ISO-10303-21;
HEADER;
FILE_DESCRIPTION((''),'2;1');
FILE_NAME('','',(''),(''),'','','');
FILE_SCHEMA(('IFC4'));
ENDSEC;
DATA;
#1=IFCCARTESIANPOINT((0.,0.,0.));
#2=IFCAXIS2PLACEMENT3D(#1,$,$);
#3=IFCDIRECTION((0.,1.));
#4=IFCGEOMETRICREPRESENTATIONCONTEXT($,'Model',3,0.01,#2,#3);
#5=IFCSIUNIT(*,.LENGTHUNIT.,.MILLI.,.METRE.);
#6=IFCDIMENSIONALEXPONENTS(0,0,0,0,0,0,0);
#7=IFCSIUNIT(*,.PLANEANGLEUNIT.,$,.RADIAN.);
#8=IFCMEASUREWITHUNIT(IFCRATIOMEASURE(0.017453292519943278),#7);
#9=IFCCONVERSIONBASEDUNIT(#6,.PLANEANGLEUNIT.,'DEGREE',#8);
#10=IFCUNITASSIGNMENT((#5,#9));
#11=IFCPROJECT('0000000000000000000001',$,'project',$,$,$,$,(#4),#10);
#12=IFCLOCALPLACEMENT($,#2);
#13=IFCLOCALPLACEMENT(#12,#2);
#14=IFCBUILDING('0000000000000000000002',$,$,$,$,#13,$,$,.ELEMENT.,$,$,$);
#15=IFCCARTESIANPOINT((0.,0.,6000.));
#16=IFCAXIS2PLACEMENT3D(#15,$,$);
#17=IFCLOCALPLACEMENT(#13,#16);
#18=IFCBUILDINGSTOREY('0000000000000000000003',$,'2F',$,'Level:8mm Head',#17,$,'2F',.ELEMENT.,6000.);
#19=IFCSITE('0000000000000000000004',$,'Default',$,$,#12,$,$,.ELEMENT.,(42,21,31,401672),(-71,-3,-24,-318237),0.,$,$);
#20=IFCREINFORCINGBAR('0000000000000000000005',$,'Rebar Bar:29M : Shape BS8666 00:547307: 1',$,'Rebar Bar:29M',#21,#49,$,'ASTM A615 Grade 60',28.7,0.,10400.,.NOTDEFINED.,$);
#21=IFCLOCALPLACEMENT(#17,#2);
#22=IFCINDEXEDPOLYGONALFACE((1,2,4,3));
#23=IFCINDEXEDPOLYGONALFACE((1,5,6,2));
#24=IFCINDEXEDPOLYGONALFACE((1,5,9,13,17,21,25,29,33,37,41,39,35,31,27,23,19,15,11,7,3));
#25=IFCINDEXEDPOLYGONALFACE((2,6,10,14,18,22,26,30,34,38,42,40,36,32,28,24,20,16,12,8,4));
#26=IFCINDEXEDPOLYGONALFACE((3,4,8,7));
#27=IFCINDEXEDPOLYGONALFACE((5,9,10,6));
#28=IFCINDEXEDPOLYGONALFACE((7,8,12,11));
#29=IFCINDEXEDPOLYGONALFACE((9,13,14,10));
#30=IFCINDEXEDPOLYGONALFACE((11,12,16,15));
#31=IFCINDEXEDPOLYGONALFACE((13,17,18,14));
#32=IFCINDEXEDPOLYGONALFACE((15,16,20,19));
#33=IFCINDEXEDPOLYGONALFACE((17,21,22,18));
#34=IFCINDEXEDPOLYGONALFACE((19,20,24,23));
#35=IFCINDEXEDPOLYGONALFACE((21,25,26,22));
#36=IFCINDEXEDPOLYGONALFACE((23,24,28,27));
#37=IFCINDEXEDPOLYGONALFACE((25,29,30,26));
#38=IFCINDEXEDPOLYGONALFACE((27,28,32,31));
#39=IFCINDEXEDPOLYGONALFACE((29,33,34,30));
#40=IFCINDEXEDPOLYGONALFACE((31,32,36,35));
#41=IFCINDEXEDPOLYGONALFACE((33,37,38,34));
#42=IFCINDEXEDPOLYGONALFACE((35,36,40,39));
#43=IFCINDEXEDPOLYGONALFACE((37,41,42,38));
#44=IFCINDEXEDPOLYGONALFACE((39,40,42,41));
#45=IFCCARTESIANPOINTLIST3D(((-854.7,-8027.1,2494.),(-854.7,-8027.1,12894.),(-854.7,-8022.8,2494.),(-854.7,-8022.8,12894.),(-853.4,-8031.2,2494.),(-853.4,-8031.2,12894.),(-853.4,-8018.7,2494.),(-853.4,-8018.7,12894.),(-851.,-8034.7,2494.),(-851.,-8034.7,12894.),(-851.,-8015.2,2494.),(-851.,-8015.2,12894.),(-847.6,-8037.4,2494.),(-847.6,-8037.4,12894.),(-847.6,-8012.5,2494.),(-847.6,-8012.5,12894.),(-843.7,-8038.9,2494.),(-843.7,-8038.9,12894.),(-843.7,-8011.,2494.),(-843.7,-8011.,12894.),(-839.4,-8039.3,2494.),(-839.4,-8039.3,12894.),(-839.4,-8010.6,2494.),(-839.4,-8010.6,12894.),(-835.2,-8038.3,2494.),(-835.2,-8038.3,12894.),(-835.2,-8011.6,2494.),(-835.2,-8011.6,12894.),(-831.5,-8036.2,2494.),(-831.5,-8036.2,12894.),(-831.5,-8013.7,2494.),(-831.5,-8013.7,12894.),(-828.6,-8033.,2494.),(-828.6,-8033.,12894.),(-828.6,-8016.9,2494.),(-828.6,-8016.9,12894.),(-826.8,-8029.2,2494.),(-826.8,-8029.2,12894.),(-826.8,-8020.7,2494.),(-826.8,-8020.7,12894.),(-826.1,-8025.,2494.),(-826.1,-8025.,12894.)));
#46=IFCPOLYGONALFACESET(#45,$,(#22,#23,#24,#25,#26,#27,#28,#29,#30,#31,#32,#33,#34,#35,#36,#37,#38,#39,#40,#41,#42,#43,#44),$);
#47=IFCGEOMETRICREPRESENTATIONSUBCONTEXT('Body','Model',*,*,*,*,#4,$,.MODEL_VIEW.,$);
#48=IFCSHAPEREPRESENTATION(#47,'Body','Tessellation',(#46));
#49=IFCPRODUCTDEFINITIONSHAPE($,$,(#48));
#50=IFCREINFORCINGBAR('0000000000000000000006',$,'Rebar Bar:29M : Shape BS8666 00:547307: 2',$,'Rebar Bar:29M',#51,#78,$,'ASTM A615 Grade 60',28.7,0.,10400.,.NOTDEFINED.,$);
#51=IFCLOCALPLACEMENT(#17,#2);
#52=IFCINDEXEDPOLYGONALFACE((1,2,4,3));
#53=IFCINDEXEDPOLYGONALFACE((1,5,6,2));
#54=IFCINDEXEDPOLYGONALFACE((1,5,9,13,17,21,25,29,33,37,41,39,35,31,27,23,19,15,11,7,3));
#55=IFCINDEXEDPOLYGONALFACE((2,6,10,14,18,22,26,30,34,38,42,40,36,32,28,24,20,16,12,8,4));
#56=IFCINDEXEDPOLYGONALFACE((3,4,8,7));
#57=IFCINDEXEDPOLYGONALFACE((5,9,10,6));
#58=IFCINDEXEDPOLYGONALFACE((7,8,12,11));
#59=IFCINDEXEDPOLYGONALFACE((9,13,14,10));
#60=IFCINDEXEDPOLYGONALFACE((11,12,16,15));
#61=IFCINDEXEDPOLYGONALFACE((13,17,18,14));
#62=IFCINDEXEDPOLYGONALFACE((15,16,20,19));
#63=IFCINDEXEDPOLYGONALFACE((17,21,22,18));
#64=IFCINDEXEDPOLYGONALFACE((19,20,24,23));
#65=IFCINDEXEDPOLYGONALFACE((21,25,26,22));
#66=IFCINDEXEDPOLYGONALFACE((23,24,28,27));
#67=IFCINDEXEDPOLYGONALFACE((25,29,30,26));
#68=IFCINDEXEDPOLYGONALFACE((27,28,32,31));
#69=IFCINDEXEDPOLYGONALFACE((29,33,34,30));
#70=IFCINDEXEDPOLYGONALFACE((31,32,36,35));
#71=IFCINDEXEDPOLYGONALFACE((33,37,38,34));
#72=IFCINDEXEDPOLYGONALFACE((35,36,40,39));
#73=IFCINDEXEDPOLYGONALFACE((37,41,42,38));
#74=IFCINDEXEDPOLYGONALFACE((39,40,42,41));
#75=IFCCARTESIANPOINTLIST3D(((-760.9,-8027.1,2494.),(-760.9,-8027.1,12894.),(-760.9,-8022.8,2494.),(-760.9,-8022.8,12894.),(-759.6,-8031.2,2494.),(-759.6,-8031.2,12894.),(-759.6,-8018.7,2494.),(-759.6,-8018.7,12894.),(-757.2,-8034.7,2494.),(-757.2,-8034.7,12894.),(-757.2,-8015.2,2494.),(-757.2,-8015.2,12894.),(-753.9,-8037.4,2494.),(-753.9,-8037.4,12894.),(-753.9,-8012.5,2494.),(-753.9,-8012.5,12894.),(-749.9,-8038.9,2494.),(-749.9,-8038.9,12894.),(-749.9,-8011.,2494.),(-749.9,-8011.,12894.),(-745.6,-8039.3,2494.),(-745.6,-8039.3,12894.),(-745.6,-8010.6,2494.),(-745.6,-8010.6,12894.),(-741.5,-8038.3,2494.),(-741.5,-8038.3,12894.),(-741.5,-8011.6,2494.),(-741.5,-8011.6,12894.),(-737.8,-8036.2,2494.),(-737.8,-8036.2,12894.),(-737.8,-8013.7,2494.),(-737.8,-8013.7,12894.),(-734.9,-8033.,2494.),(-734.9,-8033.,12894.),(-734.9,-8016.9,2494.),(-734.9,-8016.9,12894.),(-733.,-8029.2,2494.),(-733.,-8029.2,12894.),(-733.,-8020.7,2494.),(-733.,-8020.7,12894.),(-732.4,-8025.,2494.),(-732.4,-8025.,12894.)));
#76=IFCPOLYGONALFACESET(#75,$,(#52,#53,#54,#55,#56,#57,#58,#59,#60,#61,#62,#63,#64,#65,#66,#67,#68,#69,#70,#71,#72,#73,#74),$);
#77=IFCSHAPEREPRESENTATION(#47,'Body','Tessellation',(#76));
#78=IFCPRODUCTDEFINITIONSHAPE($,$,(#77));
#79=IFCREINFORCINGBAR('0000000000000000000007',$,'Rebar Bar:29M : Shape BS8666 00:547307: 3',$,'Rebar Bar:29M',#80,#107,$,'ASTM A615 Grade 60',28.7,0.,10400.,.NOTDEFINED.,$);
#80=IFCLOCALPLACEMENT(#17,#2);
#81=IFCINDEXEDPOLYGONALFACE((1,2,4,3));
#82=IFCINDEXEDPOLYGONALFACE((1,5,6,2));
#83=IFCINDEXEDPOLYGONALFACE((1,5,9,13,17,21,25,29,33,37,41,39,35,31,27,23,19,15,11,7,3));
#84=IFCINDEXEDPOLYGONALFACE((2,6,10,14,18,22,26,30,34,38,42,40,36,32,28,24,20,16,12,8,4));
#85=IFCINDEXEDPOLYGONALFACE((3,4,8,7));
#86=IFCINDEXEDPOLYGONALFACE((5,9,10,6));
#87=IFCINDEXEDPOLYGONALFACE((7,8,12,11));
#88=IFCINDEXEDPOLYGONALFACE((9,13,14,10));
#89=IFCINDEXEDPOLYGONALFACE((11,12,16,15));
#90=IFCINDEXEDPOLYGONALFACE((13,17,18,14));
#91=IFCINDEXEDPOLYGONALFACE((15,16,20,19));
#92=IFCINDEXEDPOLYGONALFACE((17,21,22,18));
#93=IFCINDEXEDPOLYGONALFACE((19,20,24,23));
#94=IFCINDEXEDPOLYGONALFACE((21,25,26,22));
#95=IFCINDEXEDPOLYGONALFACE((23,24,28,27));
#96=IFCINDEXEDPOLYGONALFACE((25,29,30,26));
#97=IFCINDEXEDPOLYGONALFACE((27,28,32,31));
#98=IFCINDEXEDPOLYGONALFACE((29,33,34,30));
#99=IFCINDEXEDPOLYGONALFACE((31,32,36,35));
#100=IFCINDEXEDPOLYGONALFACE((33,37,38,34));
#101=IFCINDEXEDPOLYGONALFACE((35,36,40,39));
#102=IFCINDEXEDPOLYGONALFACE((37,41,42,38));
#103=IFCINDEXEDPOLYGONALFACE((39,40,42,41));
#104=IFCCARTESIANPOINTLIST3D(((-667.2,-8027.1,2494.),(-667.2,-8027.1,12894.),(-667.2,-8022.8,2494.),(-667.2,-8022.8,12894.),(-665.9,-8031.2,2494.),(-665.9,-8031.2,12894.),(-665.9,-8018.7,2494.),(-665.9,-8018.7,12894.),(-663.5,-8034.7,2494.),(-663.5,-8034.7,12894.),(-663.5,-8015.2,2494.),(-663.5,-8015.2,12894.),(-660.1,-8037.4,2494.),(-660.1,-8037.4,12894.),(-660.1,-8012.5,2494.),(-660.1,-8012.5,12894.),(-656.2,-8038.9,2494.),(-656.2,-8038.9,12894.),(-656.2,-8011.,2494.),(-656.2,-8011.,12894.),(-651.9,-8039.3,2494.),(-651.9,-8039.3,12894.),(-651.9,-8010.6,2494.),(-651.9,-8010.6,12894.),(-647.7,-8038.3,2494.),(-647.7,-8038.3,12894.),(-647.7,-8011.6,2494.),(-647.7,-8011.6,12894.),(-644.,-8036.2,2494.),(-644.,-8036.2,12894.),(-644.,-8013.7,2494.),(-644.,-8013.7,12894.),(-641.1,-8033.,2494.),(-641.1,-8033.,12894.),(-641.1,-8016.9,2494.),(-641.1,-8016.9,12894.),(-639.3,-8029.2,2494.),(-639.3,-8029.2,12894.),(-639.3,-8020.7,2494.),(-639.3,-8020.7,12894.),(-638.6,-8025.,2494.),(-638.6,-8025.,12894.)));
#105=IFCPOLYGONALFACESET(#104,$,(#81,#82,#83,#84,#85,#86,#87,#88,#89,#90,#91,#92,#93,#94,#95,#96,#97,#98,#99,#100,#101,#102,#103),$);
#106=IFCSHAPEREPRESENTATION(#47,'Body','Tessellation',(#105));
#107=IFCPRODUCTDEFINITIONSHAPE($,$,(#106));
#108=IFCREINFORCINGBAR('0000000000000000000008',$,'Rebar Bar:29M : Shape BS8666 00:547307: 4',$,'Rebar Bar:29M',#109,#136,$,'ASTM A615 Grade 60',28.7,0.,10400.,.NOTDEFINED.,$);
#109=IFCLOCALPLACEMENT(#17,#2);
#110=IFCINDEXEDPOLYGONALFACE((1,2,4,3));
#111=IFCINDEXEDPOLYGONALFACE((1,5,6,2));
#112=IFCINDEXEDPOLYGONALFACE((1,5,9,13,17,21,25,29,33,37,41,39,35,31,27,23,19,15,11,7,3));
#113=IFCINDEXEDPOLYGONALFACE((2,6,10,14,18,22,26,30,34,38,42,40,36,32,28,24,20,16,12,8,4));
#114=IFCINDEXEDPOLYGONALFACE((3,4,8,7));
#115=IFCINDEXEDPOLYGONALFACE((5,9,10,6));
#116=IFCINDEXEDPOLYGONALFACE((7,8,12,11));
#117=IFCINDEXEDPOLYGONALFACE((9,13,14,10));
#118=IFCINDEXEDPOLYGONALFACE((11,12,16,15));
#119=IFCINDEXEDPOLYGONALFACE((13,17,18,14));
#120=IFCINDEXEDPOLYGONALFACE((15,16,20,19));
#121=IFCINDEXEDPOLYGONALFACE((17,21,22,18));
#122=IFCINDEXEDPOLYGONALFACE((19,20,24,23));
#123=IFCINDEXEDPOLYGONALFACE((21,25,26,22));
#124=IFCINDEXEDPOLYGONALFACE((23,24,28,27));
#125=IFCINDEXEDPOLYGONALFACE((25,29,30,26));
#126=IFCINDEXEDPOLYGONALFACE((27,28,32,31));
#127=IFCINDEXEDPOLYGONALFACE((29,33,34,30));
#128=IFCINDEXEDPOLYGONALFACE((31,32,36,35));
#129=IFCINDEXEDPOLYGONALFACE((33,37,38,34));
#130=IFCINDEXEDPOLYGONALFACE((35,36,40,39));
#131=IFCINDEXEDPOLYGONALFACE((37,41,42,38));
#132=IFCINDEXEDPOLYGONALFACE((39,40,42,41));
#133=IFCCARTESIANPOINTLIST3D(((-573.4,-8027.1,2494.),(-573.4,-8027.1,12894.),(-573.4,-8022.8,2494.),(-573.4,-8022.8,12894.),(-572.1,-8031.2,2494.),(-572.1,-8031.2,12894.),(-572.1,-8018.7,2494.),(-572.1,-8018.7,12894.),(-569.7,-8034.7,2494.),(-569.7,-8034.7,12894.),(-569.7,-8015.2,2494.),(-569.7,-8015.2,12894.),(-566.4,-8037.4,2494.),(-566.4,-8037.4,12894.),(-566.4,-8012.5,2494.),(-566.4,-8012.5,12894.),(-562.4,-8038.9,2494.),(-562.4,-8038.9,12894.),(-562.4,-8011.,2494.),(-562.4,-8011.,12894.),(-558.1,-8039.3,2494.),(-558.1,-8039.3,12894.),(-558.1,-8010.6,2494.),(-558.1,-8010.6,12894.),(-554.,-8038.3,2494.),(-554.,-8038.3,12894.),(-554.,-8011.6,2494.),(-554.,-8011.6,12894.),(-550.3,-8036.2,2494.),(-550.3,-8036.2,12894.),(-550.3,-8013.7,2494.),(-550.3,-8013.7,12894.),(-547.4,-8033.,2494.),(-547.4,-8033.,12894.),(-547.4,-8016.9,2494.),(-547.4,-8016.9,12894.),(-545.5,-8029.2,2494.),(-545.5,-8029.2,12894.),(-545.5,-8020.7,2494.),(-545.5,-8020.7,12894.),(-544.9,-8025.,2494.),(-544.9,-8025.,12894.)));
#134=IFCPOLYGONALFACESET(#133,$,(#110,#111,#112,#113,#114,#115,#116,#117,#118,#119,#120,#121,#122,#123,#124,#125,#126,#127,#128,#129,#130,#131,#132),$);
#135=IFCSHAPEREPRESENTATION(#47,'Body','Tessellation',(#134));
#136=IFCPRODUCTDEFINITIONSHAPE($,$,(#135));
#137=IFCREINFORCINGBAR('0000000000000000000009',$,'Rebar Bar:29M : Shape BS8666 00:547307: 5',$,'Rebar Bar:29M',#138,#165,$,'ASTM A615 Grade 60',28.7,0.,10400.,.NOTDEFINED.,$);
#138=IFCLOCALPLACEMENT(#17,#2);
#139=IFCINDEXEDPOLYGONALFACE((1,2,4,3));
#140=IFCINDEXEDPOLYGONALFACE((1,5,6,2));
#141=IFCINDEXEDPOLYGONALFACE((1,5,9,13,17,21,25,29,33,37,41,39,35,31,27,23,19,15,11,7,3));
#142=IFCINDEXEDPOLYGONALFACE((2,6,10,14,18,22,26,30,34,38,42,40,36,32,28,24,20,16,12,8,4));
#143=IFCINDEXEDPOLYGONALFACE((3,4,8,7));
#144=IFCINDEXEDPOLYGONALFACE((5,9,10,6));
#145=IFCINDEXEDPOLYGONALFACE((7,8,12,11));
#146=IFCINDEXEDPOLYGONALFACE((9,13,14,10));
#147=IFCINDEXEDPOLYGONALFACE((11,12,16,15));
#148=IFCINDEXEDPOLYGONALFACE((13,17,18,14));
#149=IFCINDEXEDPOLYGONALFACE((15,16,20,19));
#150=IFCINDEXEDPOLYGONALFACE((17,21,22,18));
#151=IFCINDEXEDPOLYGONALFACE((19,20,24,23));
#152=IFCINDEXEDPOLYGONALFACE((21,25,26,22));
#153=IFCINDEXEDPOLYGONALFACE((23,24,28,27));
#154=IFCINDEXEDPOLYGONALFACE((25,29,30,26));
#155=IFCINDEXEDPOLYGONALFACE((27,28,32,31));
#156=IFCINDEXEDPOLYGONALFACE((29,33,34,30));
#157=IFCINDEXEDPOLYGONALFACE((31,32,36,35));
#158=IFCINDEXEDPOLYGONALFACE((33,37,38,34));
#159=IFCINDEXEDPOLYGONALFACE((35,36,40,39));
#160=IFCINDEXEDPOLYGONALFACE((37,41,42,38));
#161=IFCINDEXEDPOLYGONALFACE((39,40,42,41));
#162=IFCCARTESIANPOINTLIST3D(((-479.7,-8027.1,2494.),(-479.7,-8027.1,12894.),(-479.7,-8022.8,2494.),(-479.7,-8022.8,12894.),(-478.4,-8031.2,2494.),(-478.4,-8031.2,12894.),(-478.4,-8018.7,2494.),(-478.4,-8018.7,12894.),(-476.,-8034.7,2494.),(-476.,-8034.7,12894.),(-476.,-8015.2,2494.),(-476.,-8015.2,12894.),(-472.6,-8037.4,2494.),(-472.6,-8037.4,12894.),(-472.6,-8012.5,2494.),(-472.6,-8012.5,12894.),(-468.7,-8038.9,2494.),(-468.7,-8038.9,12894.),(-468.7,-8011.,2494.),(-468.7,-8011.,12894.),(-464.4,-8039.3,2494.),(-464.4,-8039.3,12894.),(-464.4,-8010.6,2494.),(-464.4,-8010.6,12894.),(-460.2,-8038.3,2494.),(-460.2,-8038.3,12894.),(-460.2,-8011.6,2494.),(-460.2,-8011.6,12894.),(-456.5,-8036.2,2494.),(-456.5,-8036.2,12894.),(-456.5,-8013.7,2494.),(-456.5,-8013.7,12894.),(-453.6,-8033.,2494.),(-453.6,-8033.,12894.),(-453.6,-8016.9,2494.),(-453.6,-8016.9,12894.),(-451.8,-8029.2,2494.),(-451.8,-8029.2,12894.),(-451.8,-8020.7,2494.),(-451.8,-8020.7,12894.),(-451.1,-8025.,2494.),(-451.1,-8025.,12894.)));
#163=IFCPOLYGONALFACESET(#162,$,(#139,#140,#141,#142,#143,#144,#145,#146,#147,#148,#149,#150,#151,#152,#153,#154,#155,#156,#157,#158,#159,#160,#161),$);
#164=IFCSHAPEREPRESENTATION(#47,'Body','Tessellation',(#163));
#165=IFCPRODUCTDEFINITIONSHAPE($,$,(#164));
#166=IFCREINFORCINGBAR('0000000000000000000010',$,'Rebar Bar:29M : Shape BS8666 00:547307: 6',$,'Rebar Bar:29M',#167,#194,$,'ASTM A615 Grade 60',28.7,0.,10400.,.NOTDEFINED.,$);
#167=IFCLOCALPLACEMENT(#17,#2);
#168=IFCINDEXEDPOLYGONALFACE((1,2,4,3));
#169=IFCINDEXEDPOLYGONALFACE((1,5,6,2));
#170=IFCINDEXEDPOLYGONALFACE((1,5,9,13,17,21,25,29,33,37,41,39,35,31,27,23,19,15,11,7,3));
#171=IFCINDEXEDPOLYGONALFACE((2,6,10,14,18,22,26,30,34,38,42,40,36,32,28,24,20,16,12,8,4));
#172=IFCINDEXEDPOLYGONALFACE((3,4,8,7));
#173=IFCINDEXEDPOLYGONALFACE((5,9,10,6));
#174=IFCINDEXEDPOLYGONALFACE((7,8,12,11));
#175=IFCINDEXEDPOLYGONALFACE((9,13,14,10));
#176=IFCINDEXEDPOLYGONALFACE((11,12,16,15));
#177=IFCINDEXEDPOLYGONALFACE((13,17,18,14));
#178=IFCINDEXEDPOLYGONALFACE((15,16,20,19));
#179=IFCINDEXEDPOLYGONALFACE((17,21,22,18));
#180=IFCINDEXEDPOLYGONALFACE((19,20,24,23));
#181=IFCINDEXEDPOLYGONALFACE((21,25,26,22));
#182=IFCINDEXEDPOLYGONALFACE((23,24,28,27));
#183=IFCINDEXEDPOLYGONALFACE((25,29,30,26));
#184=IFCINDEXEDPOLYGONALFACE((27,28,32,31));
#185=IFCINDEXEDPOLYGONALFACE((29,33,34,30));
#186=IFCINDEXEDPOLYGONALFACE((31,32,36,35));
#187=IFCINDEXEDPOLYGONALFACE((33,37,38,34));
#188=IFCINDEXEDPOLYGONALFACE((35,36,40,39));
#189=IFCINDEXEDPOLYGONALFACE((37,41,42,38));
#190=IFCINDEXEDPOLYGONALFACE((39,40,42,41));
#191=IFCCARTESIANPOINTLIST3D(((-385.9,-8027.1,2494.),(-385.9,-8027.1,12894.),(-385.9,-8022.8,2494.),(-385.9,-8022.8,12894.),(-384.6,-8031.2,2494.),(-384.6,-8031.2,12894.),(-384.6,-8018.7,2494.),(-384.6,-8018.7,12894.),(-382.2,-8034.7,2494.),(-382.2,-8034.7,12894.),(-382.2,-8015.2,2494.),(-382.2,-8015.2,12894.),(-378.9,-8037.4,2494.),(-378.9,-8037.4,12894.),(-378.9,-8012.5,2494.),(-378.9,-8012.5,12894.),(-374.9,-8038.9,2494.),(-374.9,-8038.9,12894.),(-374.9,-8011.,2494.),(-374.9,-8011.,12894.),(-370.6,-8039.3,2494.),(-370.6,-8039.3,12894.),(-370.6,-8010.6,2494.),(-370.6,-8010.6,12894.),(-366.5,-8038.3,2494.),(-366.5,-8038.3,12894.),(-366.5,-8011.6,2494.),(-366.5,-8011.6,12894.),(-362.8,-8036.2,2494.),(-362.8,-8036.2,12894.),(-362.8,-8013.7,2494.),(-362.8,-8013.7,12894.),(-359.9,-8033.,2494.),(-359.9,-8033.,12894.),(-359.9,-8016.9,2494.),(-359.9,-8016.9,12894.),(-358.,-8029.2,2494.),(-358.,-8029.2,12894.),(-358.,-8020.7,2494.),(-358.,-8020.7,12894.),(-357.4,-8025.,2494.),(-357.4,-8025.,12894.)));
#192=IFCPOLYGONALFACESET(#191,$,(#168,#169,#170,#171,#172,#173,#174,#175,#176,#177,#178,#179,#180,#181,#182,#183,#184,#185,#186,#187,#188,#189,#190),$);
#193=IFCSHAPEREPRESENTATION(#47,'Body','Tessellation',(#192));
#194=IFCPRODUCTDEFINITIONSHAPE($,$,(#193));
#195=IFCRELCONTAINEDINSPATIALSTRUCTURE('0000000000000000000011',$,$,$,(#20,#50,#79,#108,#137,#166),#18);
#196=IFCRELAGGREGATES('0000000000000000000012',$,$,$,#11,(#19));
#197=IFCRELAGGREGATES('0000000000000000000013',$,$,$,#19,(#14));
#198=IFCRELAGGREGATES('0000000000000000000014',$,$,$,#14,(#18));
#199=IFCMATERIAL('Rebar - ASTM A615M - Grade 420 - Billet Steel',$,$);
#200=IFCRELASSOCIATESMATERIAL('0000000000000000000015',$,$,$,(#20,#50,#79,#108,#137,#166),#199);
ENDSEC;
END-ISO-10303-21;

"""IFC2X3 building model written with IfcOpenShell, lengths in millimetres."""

from ifc_helpers import new_model, entity, si_unit, converted_unit, direction, frame, origin, place, context, subcontext, project, spatial, material, element, save


model = new_model("IFC2X3")

# Units and contexts
model_context = context("Model", 3, precision=0.01, world=origin(), true_north=direction((0.0, 1.0)))
body_context = subcontext(model_context, "Body", "Model", "MODEL_VIEW")
ifc_project = project(units=[si_unit("LENGTHUNIT", "METRE", prefix="MILLI"), converted_unit("PLANEANGLEUNIT", "DEGREE", entity("IfcRatioMeasure", 0.017453292519943278), si_unit("PLANEANGLEUNIT", "RADIAN"), dimensions=[0, 0, 0, 0, 0, 0, 0])], contexts=[model_context])

# Site, building, storey
site_placement = place(None, origin())
site = spatial("IfcSite", under=ifc_project, at=site_placement, Name="Default", CompositionType="ELEMENT", RefLatitude=(42, 21, 31, 401672), RefLongitude=(-71, -3, -24, -318237), RefElevation=0.0)
building_placement = place(site_placement, origin())
building = spatial("IfcBuilding", under=site, at=building_placement, CompositionType="ELEMENT")
storey_placement = place(building_placement, frame((0.0, 0.0, 6000.0)))
storey = spatial("IfcBuildingStorey", under=building, at=storey_placement, Name="2F", ObjectType="Level:8mm Head", LongName="2F", CompositionType="ELEMENT", Elevation=6000.0)

# Reinforcing bars
ifc_material = material(Name="Rebar - ASTM A615M - Grade 420 - Billet Steel")
reinforcing_bar_1_placement = place(storey_placement, origin())
element("IfcReinforcingBar", 1, at=reinforcing_bar_1_placement, inside=storey, material=ifc_material, Name="Rebar Bar:29M : Shape BS8666 00:547307: 1", SteelGrade="ASTM A615 Grade 60", ObjectType="Rebar Bar:29M", BarLength=10400.0, BarRole="NOTDEFINED", CrossSectionArea=0.0, NominalDiameter=28.7, context=body_context, shape_type="AdvancedSweptSolid", body=[
    entity("IfcSweptDiskSolid", entity("IfcCompositeCurve", [entity("IfcCompositeCurveSegment", "CONTINUOUS", True, entity("IfcPolyline", [entity("IfcCartesianPoint", [-840.5, -8025.0, 2494.0]), entity("IfcCartesianPoint", [-840.5, -8025.0, 12894.0])]))], False), 14.3, None, 0.0, 1.0),
])
reinforcing_bar_2_placement = place(storey_placement, origin())
element("IfcReinforcingBar", 2, at=reinforcing_bar_2_placement, inside=storey, material=ifc_material, Name="Rebar Bar:29M : Shape BS8666 00:547307: 2", SteelGrade="ASTM A615 Grade 60", ObjectType="Rebar Bar:29M", BarLength=10400.0, BarRole="NOTDEFINED", CrossSectionArea=0.0, NominalDiameter=28.7, context=body_context, shape_type="AdvancedSweptSolid", body=[
    entity("IfcSweptDiskSolid", entity("IfcCompositeCurve", [entity("IfcCompositeCurveSegment", "CONTINUOUS", True, entity("IfcPolyline", [entity("IfcCartesianPoint", [-746.7, -8025.0, 2494.0]), entity("IfcCartesianPoint", [-746.7, -8025.0, 12894.0])]))], False), 14.3, None, 0.0, 1.0),
])
reinforcing_bar_3_placement = place(storey_placement, origin())
element("IfcReinforcingBar", 3, at=reinforcing_bar_3_placement, inside=storey, material=ifc_material, Name="Rebar Bar:29M : Shape BS8666 00:547307: 3", SteelGrade="ASTM A615 Grade 60", ObjectType="Rebar Bar:29M", BarLength=10400.0, BarRole="NOTDEFINED", CrossSectionArea=0.0, NominalDiameter=28.7, context=body_context, shape_type="AdvancedSweptSolid", body=[
    entity("IfcSweptDiskSolid", entity("IfcCompositeCurve", [entity("IfcCompositeCurveSegment", "CONTINUOUS", True, entity("IfcPolyline", [entity("IfcCartesianPoint", [-653.0, -8025.0, 2494.0]), entity("IfcCartesianPoint", [-653.0, -8025.0, 12894.0])]))], False), 14.3, None, 0.0, 1.0),
])
reinforcing_bar_4_placement = place(storey_placement, origin())
element("IfcReinforcingBar", 4, at=reinforcing_bar_4_placement, inside=storey, material=ifc_material, Name="Rebar Bar:29M : Shape BS8666 00:547307: 4", SteelGrade="ASTM A615 Grade 60", ObjectType="Rebar Bar:29M", BarLength=10400.0, BarRole="NOTDEFINED", CrossSectionArea=0.0, NominalDiameter=28.7, context=body_context, shape_type="AdvancedSweptSolid", body=[
    entity("IfcSweptDiskSolid", entity("IfcCompositeCurve", [entity("IfcCompositeCurveSegment", "CONTINUOUS", True, entity("IfcPolyline", [entity("IfcCartesianPoint", [-559.2, -8025.0, 2494.0]), entity("IfcCartesianPoint", [-559.2, -8025.0, 12894.0])]))], False), 14.3, None, 0.0, 1.0),
])
reinforcing_bar_5_placement = place(storey_placement, origin())
element("IfcReinforcingBar", 5, at=reinforcing_bar_5_placement, inside=storey, material=ifc_material, Name="Rebar Bar:29M : Shape BS8666 00:547307: 5", SteelGrade="ASTM A615 Grade 60", ObjectType="Rebar Bar:29M", BarLength=10400.0, BarRole="NOTDEFINED", CrossSectionArea=0.0, NominalDiameter=28.7, context=body_context, shape_type="AdvancedSweptSolid", body=[
    entity("IfcSweptDiskSolid", entity("IfcCompositeCurve", [entity("IfcCompositeCurveSegment", "CONTINUOUS", True, entity("IfcPolyline", [entity("IfcCartesianPoint", [-465.5, -8025.0, 2494.0]), entity("IfcCartesianPoint", [-465.5, -8025.0, 12894.0])]))], False), 14.3, None, 0.0, 1.0),
])
reinforcing_bar_6_placement = place(storey_placement, origin())
element("IfcReinforcingBar", 6, at=reinforcing_bar_6_placement, inside=storey, material=ifc_material, Name="Rebar Bar:29M : Shape BS8666 00:547307: 6", SteelGrade="ASTM A615 Grade 60", ObjectType="Rebar Bar:29M", BarLength=10400.0, BarRole="NOTDEFINED", CrossSectionArea=0.0, NominalDiameter=28.7, context=body_context, shape_type="AdvancedSweptSolid", body=[
    entity("IfcSweptDiskSolid", entity("IfcCompositeCurve", [entity("IfcCompositeCurveSegment", "CONTINUOUS", True, entity("IfcPolyline", [entity("IfcCartesianPoint", [-371.7, -8025.0, 2494.0]), entity("IfcCartesianPoint", [-371.7, -8025.0, 12894.0])]))], False), 14.3, None, 0.0, 1.0),
])

save(model, "model.ifc")
